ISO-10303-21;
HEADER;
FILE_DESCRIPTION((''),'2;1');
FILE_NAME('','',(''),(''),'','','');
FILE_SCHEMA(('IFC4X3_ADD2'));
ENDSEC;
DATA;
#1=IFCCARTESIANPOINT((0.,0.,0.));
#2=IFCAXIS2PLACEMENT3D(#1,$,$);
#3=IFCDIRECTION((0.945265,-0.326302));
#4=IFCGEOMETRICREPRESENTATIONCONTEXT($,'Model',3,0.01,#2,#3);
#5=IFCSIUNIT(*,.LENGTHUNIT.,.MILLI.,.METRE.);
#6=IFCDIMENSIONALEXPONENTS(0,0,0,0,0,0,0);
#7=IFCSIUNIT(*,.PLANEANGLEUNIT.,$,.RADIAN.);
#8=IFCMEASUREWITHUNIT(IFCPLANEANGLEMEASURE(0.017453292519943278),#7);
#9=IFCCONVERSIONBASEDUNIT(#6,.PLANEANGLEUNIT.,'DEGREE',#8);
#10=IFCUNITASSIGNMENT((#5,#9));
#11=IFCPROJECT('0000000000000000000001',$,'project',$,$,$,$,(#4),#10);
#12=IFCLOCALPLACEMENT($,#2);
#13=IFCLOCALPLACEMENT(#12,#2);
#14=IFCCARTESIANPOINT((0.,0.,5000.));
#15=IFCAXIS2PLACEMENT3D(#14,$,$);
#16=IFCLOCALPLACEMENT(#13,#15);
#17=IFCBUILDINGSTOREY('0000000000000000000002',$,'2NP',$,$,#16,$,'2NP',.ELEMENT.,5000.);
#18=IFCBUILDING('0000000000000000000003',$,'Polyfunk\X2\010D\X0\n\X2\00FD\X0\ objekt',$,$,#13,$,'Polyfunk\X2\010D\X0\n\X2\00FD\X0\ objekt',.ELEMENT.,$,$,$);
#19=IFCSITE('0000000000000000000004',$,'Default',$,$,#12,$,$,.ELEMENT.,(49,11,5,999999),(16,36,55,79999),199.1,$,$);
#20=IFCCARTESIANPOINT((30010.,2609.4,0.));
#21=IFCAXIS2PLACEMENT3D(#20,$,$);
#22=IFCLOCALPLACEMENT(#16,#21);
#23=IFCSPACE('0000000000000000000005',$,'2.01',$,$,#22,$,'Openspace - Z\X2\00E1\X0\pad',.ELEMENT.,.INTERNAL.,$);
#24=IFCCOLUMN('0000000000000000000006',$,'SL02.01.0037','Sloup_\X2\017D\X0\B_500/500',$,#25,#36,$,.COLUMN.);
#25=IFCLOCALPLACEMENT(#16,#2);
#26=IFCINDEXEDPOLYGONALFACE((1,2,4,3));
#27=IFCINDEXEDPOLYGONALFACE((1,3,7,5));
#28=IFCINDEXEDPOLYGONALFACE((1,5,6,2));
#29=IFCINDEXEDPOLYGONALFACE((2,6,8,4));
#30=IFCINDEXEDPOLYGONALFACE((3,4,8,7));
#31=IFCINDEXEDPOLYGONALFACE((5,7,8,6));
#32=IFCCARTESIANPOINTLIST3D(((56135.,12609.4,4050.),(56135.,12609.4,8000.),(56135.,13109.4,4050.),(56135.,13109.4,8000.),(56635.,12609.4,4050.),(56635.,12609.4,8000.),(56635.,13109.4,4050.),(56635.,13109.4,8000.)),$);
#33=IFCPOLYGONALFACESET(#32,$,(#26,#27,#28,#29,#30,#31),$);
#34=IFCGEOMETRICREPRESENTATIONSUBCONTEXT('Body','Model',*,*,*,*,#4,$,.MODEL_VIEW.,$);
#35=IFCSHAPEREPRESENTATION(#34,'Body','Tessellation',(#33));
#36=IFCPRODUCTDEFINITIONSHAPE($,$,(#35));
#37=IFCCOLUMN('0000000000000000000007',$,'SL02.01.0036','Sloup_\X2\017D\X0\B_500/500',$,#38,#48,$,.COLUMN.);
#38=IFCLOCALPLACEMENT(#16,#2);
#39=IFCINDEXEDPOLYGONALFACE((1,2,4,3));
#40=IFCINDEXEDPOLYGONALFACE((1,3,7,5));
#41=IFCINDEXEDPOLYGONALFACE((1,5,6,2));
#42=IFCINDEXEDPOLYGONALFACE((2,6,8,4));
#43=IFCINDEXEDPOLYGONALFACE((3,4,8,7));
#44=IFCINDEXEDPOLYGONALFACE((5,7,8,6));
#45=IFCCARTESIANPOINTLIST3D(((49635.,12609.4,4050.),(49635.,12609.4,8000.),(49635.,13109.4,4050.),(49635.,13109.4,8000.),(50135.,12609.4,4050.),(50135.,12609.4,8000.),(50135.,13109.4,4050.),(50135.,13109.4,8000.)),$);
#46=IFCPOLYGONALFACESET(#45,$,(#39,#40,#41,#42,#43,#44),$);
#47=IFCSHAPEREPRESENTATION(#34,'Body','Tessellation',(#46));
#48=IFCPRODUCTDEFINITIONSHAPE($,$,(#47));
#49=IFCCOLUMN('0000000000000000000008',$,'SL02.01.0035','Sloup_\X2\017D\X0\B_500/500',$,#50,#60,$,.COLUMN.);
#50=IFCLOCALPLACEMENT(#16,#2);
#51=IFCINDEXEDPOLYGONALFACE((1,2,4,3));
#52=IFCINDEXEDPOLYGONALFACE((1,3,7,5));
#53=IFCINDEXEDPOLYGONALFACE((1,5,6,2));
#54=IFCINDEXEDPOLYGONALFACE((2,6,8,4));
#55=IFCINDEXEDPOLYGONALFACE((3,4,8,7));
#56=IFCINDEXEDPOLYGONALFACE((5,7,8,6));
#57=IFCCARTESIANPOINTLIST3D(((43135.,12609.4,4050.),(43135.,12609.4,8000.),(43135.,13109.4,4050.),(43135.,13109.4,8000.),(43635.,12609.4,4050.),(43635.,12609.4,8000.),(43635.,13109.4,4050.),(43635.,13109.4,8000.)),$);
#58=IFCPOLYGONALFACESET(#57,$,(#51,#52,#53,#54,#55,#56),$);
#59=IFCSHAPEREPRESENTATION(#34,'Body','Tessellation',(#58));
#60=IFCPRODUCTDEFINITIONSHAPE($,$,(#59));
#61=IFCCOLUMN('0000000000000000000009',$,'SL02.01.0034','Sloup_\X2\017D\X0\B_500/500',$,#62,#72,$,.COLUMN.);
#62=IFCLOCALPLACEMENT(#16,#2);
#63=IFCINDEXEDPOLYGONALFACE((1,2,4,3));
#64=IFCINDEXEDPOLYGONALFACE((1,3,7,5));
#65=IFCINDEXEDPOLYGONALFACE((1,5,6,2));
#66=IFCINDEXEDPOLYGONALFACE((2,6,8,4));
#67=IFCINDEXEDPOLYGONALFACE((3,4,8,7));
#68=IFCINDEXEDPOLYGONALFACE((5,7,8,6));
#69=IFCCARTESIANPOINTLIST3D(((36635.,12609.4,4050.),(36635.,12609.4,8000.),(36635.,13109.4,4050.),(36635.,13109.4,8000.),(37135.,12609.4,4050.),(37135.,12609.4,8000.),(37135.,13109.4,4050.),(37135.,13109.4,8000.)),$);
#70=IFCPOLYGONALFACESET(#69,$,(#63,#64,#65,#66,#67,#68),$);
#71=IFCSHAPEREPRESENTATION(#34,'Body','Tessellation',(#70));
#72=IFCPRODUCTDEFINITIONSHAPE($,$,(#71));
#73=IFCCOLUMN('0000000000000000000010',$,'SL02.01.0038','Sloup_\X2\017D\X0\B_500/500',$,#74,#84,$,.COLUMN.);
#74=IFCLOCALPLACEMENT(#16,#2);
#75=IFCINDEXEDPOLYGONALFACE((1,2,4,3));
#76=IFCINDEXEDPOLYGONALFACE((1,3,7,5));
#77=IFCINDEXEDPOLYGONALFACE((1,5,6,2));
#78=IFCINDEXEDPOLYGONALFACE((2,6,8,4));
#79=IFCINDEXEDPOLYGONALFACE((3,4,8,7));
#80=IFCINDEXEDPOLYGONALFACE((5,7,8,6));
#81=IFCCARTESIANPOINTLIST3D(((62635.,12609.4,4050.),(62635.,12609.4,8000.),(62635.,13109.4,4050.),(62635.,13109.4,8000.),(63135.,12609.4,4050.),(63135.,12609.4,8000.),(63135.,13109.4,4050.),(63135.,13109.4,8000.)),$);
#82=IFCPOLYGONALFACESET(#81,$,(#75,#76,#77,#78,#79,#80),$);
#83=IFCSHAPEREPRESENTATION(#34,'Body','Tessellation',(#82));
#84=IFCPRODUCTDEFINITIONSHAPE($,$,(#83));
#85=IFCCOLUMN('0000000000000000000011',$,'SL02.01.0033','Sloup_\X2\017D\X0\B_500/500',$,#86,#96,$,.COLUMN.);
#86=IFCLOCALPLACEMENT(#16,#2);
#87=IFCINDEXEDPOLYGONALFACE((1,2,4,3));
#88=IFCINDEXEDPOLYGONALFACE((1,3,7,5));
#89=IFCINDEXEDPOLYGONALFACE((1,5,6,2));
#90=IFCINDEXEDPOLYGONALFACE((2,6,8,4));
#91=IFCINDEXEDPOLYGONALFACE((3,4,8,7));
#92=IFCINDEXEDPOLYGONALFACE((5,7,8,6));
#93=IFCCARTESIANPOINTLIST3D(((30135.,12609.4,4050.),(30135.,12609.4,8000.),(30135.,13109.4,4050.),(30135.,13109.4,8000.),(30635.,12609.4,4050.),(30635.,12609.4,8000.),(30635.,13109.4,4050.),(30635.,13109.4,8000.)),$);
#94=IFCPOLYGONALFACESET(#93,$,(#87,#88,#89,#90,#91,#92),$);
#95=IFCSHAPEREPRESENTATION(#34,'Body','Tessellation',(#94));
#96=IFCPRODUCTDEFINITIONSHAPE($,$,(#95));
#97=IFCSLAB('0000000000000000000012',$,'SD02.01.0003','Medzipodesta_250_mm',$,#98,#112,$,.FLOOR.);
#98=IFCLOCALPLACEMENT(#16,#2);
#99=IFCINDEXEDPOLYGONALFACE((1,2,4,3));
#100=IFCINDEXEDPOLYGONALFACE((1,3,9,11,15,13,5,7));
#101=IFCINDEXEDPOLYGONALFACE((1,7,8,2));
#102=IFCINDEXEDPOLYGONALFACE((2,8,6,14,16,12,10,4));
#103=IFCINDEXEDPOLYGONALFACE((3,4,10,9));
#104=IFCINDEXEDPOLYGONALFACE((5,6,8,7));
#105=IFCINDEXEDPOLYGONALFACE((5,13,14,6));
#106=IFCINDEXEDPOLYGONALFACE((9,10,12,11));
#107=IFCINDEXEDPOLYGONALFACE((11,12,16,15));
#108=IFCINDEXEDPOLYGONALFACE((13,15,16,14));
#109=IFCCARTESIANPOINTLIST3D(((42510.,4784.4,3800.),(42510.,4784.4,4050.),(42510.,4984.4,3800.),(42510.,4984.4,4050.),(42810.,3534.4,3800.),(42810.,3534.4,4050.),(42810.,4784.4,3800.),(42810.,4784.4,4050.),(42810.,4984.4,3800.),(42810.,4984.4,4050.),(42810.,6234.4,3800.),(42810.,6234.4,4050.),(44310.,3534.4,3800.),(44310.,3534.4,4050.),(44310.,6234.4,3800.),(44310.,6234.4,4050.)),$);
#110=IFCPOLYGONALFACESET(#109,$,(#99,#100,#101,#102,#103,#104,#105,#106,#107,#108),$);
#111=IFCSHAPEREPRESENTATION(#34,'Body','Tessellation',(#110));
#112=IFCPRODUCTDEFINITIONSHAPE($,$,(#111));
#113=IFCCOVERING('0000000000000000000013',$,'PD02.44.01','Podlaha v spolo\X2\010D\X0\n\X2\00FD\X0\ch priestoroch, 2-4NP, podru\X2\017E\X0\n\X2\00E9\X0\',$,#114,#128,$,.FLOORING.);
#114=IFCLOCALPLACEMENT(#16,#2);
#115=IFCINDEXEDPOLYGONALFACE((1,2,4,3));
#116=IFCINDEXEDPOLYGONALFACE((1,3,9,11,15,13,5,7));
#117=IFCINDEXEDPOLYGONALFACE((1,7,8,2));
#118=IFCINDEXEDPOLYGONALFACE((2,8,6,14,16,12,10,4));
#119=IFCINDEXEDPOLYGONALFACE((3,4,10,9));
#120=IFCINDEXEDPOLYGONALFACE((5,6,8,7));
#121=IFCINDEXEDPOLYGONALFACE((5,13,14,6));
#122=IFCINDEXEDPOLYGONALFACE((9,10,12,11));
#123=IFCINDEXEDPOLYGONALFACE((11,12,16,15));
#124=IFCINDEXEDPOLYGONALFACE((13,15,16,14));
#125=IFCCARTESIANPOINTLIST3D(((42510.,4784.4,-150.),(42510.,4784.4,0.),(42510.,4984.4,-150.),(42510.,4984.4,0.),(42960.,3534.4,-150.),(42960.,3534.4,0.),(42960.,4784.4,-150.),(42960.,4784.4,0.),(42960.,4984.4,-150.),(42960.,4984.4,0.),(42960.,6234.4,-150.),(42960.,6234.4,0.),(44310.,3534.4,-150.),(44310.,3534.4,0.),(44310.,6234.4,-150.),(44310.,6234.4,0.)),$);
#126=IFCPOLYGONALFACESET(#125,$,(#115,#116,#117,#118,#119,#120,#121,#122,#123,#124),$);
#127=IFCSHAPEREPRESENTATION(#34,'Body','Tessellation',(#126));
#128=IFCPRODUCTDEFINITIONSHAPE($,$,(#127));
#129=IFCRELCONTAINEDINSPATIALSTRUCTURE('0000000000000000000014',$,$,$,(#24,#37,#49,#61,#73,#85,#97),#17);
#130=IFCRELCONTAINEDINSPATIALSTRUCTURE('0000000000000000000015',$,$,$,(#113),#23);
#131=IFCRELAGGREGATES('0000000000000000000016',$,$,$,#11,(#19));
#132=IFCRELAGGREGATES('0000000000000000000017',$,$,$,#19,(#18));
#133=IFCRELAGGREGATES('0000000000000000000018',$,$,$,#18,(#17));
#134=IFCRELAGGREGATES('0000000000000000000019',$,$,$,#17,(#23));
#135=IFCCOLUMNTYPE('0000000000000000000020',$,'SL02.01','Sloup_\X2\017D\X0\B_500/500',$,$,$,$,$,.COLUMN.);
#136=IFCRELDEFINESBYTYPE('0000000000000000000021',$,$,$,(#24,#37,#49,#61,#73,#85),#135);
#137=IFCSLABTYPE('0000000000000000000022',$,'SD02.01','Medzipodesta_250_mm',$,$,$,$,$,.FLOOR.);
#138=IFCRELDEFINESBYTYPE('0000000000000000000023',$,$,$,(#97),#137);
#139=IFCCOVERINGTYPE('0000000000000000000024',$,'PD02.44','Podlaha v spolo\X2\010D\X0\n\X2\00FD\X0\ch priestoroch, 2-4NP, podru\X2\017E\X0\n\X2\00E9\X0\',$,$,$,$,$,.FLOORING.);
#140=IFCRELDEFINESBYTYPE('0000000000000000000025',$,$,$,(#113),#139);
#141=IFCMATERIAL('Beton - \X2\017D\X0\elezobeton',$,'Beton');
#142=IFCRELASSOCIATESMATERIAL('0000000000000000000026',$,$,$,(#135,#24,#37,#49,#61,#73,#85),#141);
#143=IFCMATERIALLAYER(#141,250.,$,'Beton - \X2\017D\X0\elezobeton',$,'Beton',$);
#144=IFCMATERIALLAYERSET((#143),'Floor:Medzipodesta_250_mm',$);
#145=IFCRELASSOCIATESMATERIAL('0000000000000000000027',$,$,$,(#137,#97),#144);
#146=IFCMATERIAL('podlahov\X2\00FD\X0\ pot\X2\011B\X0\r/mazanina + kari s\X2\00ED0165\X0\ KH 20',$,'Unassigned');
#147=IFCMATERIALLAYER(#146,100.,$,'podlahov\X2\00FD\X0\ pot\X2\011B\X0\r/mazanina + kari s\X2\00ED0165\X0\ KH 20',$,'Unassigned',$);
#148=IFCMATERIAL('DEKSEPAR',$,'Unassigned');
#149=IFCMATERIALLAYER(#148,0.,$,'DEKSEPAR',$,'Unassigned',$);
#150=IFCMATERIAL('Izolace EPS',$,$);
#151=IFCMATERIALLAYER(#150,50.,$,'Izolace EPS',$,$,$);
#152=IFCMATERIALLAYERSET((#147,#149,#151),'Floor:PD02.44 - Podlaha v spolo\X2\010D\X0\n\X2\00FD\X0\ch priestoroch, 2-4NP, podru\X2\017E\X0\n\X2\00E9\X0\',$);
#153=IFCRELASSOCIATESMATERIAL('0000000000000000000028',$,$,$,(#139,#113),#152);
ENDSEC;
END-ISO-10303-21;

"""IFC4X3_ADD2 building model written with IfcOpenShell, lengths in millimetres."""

from ifc_helpers import new_model, entity, si_unit, converted_unit, direction, frame, frame_2d, origin, origin_2d_with_axis, place, context, subcontext, project, spatial, polyline, rectangle, outline, extrude, source, transform, mapped, material, layer, layer_set, layer_usage, material_profile, profile_set, profile_usage, type_object, type_shapes, element, save


model = new_model("IFC4X3_ADD2")

# Units and contexts
model_context = context("Model", 3, precision=0.01, world=origin(), true_north=direction((0.945265, -0.326302)))
body_context = subcontext(model_context, "Body", "Model", "MODEL_VIEW")
ifc_project = project(units=[si_unit("LENGTHUNIT", "METRE", prefix="MILLI"), converted_unit("PLANEANGLEUNIT", "DEGREE", entity("IfcPlaneAngleMeasure", 0.017453292519943278), si_unit("PLANEANGLEUNIT", "RADIAN"), dimensions=[0, 0, 0, 0, 0, 0, 0])], contexts=[model_context])

# Site, building, storey
site_placement = place(None, origin())
site = spatial("IfcSite", under=ifc_project, at=site_placement, Name="Default", CompositionType="ELEMENT", RefLatitude=(49, 11, 5, 999999), RefLongitude=(16, 36, 55, 79999), RefElevation=199.1)
building_placement = place(site_placement, origin())
building = spatial("IfcBuilding", under=site, at=building_placement, Name="Polyfunkčný objekt", LongName="Polyfunkčný objekt", CompositionType="ELEMENT")
storey_placement = place(building_placement, frame((0.0, 0.0, 5000.0)))
storey = spatial("IfcBuildingStorey", under=building, at=storey_placement, Name="2NP", LongName="2NP", CompositionType="ELEMENT", Elevation=5000.0)

# Columns
ifc_material_1 = material(Name="Beton - Železobeton", Category="Beton")
ifc_material_profile_1 = material_profile(ifc_material_1, rectangle(XDim=500.0, YDim=500.0, at=frame_2d((0.0, 0.0), x_axis=(1.0, 0.0))), Name="Sloup_ŽB_500/500")
ifc_profile_set_1 = profile_set([ifc_material_profile_1], Name="Sloup_ŽB_500/500")
ifc_profile_usage_1 = profile_usage(ifc_profile_set_1)
column_type = type_object("IfcColumnType", Name="SL02.01", Description="Sloup_ŽB_500/500", PredefinedType="COLUMN", material=ifc_profile_set_1)
shared_shape_1 = source(origin(), body_context, "Body", "SweptSolid", [
    extrude(rectangle(XDim=500.0, YDim=500.0, at=frame_2d((0.0, 0.0), x_axis=(1.0, 0.0))), frame((56385.0, 12859.4, 9050.0)), (0.0, 0.0, 1.0), 3950.0),
])
column_1_placement = place(storey_placement, frame((0.0, 0.0, -5000.0)))
element("IfcColumn", 1, at=column_1_placement, inside=storey, type_object=column_type, material=ifc_profile_usage_1, Name="SL02.01.0037", Description="Sloup_ŽB_500/500", PredefinedType="COLUMN", context=body_context, shape_type="MappedRepresentation", body=[
    mapped(shared_shape_1, transform((0.0, 0.0, 0.0), scale=1.0)),
])
shared_shape_2 = source(origin(), body_context, "Body", "SweptSolid", [
    extrude(rectangle(XDim=500.0, YDim=500.0, at=origin_2d_with_axis()), frame((49885.0, 12859.4, 9050.0)), (0.0, 0.0, 1.0), 3950.0),
])
column_2_placement = place(storey_placement, frame((0.0, 0.0, -5000.0)))
element("IfcColumn", 2, at=column_2_placement, inside=storey, type_object=column_type, material=ifc_profile_usage_1, Name="SL02.01.0036", Description="Sloup_ŽB_500/500", PredefinedType="COLUMN", context=body_context, shape_type="MappedRepresentation", body=[
    mapped(shared_shape_2, transform((0.0, 0.0, 0.0), scale=1.0)),
])
shared_shape_3 = source(origin(), body_context, "Body", "SweptSolid", [
    extrude(rectangle(XDim=500.0, YDim=500.0, at=origin_2d_with_axis()), frame((43385.0, 12859.4, 9050.0)), (0.0, 0.0, 1.0), 3950.0),
])
column_3_placement = place(storey_placement, frame((0.0, 0.0, -5000.0)))
element("IfcColumn", 3, at=column_3_placement, inside=storey, type_object=column_type, material=ifc_profile_usage_1, Name="SL02.01.0035", Description="Sloup_ŽB_500/500", PredefinedType="COLUMN", context=body_context, shape_type="MappedRepresentation", body=[
    mapped(shared_shape_3, transform((0.0, 0.0, 0.0), scale=1.0)),
])
shared_shape_4 = source(origin(), body_context, "Body", "SweptSolid", [
    extrude(rectangle(XDim=500.0, YDim=500.0, at=origin_2d_with_axis()), frame((36885.0, 12859.4, 9050.0)), (0.0, 0.0, 1.0), 3950.0),
])
column_4_placement = place(storey_placement, frame((0.0, 0.0, -5000.0)))
element("IfcColumn", 4, at=column_4_placement, inside=storey, type_object=column_type, material=ifc_profile_usage_1, Name="SL02.01.0034", Description="Sloup_ŽB_500/500", PredefinedType="COLUMN", context=body_context, shape_type="MappedRepresentation", body=[
    mapped(shared_shape_4, transform((0.0, 0.0, 0.0), scale=1.0)),
])
shared_shape_5 = source(origin(), body_context, "Body", "SweptSolid", [
    extrude(rectangle(XDim=500.0, YDim=500.0, at=origin_2d_with_axis()), frame((62885.0, 12859.4, 9050.0), z_axis=(0.0, 0.0, 1.0), x_axis=(-1.0, 0.0, 0.0)), (0.0, 0.0, 1.0), 3950.0),
])
column_5_placement = place(storey_placement, frame((0.0, 0.0, -5000.0)))
element("IfcColumn", 5, at=column_5_placement, inside=storey, type_object=column_type, material=ifc_profile_usage_1, Name="SL02.01.0038", Description="Sloup_ŽB_500/500", PredefinedType="COLUMN", context=body_context, shape_type="MappedRepresentation", body=[
    mapped(shared_shape_5, transform((0.0, 0.0, 0.0), scale=1.0)),
])
shared_shape_6 = source(origin(), body_context, "Body", "SweptSolid", [
    extrude(rectangle(XDim=500.0, YDim=500.0, at=origin_2d_with_axis()), frame((30385.0, 12859.4, 9050.0), z_axis=(0.0, 0.0, 1.0), x_axis=(-1.0, 0.0, 0.0)), (0.0, 0.0, 1.0), 3950.0),
])
type_shapes(column_type, [shared_shape_1, shared_shape_2, shared_shape_3, shared_shape_4, shared_shape_5, shared_shape_6])
column_6_placement = place(storey_placement, frame((0.0, 0.0, -5000.0)))
element("IfcColumn", 6, at=column_6_placement, inside=storey, type_object=column_type, material=ifc_profile_usage_1, Name="SL02.01.0033", Description="Sloup_ŽB_500/500", PredefinedType="COLUMN", context=body_context, shape_type="MappedRepresentation", body=[
    mapped(shared_shape_6, transform((0.0, 0.0, 0.0), scale=1.0)),
])

# Slab
ifc_layer_1 = layer(ifc_material_1, 250.0, Name="Beton - Železobeton", Category="Beton")
ifc_layer_set_1 = layer_set([ifc_layer_1], Name="Floor:Medzipodesta_250_mm")
ifc_layer_usage_1 = layer_usage(ifc_layer_set_1, "AXIS3", "POSITIVE", 0.0)
slab_type_1 = type_object("IfcSlabType", Name="SD02.01", Description="Medzipodesta_250_mm", PredefinedType="FLOOR", material=ifc_layer_set_1)
slab_1_placement = place(storey_placement, origin())
element("IfcSlab", 7, at=slab_1_placement, inside=storey, type_object=slab_type_1, material=ifc_layer_usage_1, Name="SD02.01.0003", Description="Medzipodesta_250_mm", PredefinedType="FLOOR", context=body_context, shape_type="SweptSolid", body=[
    extrude(outline(polyline([(-100.0, -600.0), (100.0, -600.0), (100.0, -300.0), (1350.0, -300.0), (1350.0, 1200.0), (-1350.0, 1200.0), (-1350.0, -300.0), (-100.0, -300.0), (-100.0, -600.0)])), frame((43110.0, 4884.4, 4050.0), z_axis=(0.0, 0.0, -1.0), x_axis=(0.0, 1.0, 0.0)), (0.0, 0.0, 1.0), 250.0),
])

# Shared definitions
space_1_placement = place(storey_placement, frame((30010.0, 2609.4, 0.0)))
space_1 = spatial("IfcSpace", under=storey, at=space_1_placement, Name="2.01", LongName="Openspace - Západ", CompositionType="ELEMENT", PredefinedType="INTERNAL")

# Covering
ifc_material_2 = material(Name="podlahový potěr/mazanina + kari síť KH 20", Category="Unassigned")
ifc_layer_2 = layer(ifc_material_2, 100.0, Name="podlahový potěr/mazanina + kari síť KH 20", Category="Unassigned")
ifc_material_3 = material(Name="DEKSEPAR", Category="Unassigned")
ifc_layer_3 = layer(ifc_material_3, 0.0, Name="DEKSEPAR", Category="Unassigned")
ifc_material_4 = material(Name="Izolace EPS")
ifc_layer_4 = layer(ifc_material_4, 50.0, Name="Izolace EPS")
ifc_layer_set_2 = layer_set([ifc_layer_2, ifc_layer_3, ifc_layer_4], Name="Floor:PD02.44 - Podlaha v spoločných priestoroch, 2-4NP, podružné")
ifc_layer_usage_2 = layer_usage(ifc_layer_set_2, "AXIS3", "POSITIVE", 0.0)
covering_type_1 = type_object("IfcCoveringType", Name="PD02.44", Description="Podlaha v spoločných priestoroch, 2-4NP, podružné", PredefinedType="FLOORING", material=ifc_layer_set_2)
covering_1_placement = place(storey_placement, origin())
element("IfcCovering", 8, at=covering_1_placement, inside=space_1, type_object=covering_type_1, material=ifc_layer_usage_2, Name="PD02.44.01", Description="Podlaha v spoločných priestoroch, 2-4NP, podružné", PredefinedType="FLOORING", context=body_context, shape_type="SweptSolid", body=[
    extrude(outline(polyline([(-100.0, -675.0), (100.0, -675.0), (100.0, -225.0), (1350.0, -225.0), (1350.0, 1125.0), (-1350.0, 1125.0), (-1350.0, -225.0), (-100.0, -225.0), (-100.0, -675.0)])), frame((43185.0, 4884.4, 0.0), z_axis=(0.0, 0.0, -1.0), x_axis=(0.0, 1.0, 0.0)), (0.0, 0.0, 1.0), 150.0),
])

save(model, "model.ifc")
